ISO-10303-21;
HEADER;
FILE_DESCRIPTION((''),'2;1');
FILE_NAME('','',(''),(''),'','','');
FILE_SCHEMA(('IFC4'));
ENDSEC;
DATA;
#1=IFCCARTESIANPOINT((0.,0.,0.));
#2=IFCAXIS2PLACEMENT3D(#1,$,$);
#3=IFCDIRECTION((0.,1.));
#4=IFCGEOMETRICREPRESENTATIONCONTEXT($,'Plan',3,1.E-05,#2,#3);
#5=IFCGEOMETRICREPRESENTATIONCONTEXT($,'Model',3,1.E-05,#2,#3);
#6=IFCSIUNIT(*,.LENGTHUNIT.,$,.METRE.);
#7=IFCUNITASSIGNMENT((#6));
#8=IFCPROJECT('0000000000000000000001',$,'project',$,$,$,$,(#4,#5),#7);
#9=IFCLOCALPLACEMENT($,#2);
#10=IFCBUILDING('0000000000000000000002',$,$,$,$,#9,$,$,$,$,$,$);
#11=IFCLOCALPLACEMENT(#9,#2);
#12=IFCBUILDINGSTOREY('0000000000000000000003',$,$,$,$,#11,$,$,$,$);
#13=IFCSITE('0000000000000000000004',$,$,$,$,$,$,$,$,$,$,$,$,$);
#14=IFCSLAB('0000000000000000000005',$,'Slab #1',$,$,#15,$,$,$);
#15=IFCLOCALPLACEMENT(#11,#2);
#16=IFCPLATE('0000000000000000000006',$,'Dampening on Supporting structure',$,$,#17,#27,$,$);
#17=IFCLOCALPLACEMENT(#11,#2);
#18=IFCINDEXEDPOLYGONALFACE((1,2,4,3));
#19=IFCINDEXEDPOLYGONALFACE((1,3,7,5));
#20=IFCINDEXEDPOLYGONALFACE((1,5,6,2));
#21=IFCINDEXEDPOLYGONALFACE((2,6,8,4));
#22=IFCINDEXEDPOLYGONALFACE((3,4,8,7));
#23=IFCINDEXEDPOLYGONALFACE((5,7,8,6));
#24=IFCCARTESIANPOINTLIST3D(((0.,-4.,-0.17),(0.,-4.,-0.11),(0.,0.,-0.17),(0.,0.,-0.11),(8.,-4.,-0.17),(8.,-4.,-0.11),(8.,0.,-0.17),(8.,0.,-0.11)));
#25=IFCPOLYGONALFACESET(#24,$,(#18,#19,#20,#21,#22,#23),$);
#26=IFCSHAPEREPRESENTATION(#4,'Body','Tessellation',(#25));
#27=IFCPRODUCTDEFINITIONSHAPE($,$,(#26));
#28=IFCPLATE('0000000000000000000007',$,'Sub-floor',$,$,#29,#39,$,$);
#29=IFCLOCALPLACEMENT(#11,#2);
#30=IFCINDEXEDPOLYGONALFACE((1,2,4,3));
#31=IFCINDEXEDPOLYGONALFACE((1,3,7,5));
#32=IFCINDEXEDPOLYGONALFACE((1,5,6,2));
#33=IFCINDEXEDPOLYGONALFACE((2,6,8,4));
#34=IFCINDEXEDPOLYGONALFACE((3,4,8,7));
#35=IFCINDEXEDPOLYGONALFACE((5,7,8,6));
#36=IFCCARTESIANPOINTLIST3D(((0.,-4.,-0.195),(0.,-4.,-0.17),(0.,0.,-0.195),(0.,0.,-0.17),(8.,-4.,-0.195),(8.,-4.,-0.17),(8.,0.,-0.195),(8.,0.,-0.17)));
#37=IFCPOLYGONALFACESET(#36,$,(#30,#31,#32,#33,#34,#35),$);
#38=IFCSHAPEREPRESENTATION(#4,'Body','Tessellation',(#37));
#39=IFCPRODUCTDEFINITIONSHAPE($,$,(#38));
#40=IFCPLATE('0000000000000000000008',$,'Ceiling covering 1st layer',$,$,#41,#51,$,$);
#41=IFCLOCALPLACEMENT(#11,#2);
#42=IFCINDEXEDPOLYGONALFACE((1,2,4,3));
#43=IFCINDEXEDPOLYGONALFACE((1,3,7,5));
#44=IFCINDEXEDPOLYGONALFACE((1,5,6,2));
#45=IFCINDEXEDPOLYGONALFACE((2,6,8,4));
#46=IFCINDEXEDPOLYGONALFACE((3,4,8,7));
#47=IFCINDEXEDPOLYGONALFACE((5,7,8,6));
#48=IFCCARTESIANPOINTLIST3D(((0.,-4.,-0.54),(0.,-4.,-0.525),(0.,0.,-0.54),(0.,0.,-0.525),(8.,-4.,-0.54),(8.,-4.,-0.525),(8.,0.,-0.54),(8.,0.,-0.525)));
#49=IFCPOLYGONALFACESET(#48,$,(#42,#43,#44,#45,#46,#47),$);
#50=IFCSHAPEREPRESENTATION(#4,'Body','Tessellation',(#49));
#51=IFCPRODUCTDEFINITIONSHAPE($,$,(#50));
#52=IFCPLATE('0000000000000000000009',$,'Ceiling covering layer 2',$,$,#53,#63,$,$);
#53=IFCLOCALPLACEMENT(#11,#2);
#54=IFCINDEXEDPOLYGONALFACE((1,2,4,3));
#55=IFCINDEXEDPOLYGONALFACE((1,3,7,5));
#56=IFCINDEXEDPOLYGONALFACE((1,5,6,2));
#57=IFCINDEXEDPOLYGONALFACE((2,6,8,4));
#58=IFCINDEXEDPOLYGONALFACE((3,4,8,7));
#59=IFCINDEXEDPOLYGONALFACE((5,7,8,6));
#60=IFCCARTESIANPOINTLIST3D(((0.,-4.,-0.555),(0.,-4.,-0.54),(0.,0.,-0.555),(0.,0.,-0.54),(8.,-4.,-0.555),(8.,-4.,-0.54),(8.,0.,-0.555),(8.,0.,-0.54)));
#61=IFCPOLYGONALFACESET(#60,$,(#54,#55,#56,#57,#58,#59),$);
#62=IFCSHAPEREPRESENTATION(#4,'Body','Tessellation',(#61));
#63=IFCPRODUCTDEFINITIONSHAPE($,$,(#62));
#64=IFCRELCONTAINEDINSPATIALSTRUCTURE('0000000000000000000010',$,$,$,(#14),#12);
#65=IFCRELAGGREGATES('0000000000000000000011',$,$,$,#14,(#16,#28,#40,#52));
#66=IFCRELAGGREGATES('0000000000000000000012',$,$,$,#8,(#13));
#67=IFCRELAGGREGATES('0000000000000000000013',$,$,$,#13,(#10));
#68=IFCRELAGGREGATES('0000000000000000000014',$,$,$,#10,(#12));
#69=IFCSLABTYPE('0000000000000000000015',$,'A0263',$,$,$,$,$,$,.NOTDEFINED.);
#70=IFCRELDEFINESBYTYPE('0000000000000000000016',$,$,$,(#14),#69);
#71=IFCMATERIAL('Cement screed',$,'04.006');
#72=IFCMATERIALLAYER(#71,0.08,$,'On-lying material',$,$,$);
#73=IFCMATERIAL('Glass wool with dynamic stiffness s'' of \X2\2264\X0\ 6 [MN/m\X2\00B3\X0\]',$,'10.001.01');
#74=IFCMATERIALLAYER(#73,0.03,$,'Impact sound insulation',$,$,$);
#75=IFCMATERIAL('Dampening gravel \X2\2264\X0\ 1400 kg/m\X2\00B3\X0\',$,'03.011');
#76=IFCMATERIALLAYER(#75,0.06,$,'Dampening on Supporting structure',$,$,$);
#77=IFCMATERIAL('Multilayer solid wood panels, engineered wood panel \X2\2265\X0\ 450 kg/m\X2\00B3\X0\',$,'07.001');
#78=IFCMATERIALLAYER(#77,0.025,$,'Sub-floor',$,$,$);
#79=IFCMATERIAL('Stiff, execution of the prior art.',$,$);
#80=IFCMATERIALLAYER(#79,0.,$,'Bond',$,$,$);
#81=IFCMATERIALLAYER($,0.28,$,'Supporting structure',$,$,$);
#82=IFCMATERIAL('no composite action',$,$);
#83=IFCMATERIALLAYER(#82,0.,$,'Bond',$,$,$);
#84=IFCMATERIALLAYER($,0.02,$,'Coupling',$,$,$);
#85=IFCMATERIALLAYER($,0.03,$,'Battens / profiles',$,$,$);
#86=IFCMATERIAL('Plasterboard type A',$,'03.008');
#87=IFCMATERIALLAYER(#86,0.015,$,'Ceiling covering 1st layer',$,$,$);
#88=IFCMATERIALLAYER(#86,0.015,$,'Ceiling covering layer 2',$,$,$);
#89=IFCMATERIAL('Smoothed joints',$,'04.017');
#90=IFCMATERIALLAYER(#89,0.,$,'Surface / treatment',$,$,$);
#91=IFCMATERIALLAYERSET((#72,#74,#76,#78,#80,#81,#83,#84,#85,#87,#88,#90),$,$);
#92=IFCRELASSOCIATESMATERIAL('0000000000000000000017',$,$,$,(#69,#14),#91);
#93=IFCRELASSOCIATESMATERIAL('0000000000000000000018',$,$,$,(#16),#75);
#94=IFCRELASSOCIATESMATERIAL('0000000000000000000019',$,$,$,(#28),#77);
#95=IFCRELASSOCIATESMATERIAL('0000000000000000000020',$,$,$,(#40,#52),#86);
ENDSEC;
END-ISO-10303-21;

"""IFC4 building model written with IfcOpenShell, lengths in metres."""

from ifc_helpers import new_model, si_unit, direction, frame, frame_2d, origin, place, context, project, spatial, rectangle, extrude, material, layer, layer_set, type_object, element, aggregate, save


model = new_model("IFC4")

# Units and contexts
plan_context = context("Plan", 3, precision=1e-05, world=origin(), true_north=direction((0.0, 1.0)))
model_context = context("Model", 3, precision=1e-05, world=origin(), true_north=direction((0.0, 1.0)))
ifc_project = project(units=[si_unit("LENGTHUNIT", "METRE")], contexts=[plan_context, model_context])

# Site, building, storey
site = spatial("IfcSite", under=ifc_project)
building_placement = place(None, origin())
building = spatial("IfcBuilding", under=site, at=building_placement)
storey_placement = place(building_placement, origin())
storey = spatial("IfcBuildingStorey", under=building, at=storey_placement)

# Slab, plates
ifc_material_1 = material(Name="Cement screed", Category="04.006")
ifc_layer_1 = layer(ifc_material_1, 0.08, Name="On-lying material")
ifc_material_2 = material(Name="Glass wool with dynamic stiffness s' of ≤ 6 [MN/m³]", Category="10.001.01")
ifc_layer_2 = layer(ifc_material_2, 0.03, Name="Impact sound insulation")
ifc_material_3 = material(Name="Dampening gravel ≤ 1400 kg/m³", Category="03.011")
ifc_layer_3 = layer(ifc_material_3, 0.06, Name="Dampening on Supporting structure")
ifc_material_4 = material(Name="Multilayer solid wood panels, engineered wood panel ≥ 450 kg/m³", Category="07.001")
ifc_layer_4 = layer(ifc_material_4, 0.025, Name="Sub-floor")
ifc_material_5 = material(Name="Stiff, execution of the prior art.")
ifc_layer_5 = layer(ifc_material_5, 0.0, Name="Bond")
ifc_layer_6 = layer(None, 0.28, Name="Supporting structure")
ifc_material_6 = material(Name="no composite action")
ifc_layer_7 = layer(ifc_material_6, 0.0, Name="Bond")
ifc_layer_8 = layer(None, 0.02, Name="Coupling")
ifc_layer_9 = layer(None, 0.03, Name="Battens / profiles")
ifc_material_7 = material(Name="Plasterboard type A", Category="03.008")
ifc_layer_10 = layer(ifc_material_7, 0.015, Name="Ceiling covering 1st layer")
ifc_layer_11 = layer(ifc_material_7, 0.015, Name="Ceiling covering layer 2")
ifc_material_8 = material(Name="Smoothed joints", Category="04.017")
ifc_layer_12 = layer(ifc_material_8, 0.0, Name="Surface / treatment")
ifc_layer_set = layer_set([ifc_layer_1, ifc_layer_2, ifc_layer_3, ifc_layer_4, ifc_layer_5, ifc_layer_6, ifc_layer_7, ifc_layer_8, ifc_layer_9, ifc_layer_10, ifc_layer_11, ifc_layer_12])
slab_type = type_object("IfcSlabType", Name="A0263", PredefinedType="NOTDEFINED", material=ifc_layer_set)
slab_placement = place(None, frame((0.0, 0.0, 0.0), z_axis=(0.0, 0.0, -1.0), x_axis=(1.0, 0.0, 0.0)))
slab = element("IfcSlab", 1, at=slab_placement, inside=storey, type_object=slab_type, material=ifc_layer_set, Name="Slab #1")
plate_1_placement = place(slab_placement, origin())
plate_1 = element("IfcPlate", 2, at=plate_1_placement, material=ifc_material_3, Name="Dampening on Supporting structure", context=plan_context, shape_type="SweptSolid", body=[
    extrude(rectangle(XDim=8.0, YDim=4.0, at=frame_2d((4.0, 2.0), x_axis=(1.0, 0.0))), frame((0.0, 0.0, 0.11), z_axis=(0.0, 0.0, 1.0), x_axis=(1.0, 0.0, 0.0)), (0.0, 0.0, 1.0), 0.06),
])
plate_2_placement = place(slab_placement, origin())
plate_2 = element("IfcPlate", 3, at=plate_2_placement, material=ifc_material_4, Name="Sub-floor", context=plan_context, shape_type="SweptSolid", body=[
    extrude(rectangle(XDim=8.0, YDim=4.0, at=frame_2d((4.0, 2.0), x_axis=(1.0, 0.0))), frame((0.0, 0.0, 0.17), z_axis=(0.0, 0.0, 1.0), x_axis=(1.0, 0.0, 0.0)), (0.0, 0.0, 1.0), 0.025),
])
plate_3_placement = place(slab_placement, origin())
plate_3 = element("IfcPlate", 4, at=plate_3_placement, material=ifc_material_7, Name="Ceiling covering 1st layer", context=plan_context, shape_type="SweptSolid", body=[
    extrude(rectangle(XDim=8.0, YDim=4.0, at=frame_2d((4.0, 2.0), x_axis=(1.0, 0.0))), frame((0.0, 0.0, 0.525), z_axis=(0.0, 0.0, 1.0), x_axis=(1.0, 0.0, 0.0)), (0.0, 0.0, 1.0), 0.015),
])
plate_4_placement = place(slab_placement, origin())
plate_4 = element("IfcPlate", 5, at=plate_4_placement, material=ifc_material_7, Name="Ceiling covering layer 2", context=plan_context, shape_type="SweptSolid", body=[
    extrude(rectangle(XDim=8.0, YDim=4.0, at=frame_2d((4.0, 2.0), x_axis=(1.0, 0.0))), frame((0.0, 0.0, 0.54), z_axis=(0.0, 0.0, 1.0), x_axis=(1.0, 0.0, 0.0)), (0.0, 0.0, 1.0), 0.015),
])
aggregate(slab, [plate_1, plate_2, plate_3, plate_4])

save(model, "model.ifc")
